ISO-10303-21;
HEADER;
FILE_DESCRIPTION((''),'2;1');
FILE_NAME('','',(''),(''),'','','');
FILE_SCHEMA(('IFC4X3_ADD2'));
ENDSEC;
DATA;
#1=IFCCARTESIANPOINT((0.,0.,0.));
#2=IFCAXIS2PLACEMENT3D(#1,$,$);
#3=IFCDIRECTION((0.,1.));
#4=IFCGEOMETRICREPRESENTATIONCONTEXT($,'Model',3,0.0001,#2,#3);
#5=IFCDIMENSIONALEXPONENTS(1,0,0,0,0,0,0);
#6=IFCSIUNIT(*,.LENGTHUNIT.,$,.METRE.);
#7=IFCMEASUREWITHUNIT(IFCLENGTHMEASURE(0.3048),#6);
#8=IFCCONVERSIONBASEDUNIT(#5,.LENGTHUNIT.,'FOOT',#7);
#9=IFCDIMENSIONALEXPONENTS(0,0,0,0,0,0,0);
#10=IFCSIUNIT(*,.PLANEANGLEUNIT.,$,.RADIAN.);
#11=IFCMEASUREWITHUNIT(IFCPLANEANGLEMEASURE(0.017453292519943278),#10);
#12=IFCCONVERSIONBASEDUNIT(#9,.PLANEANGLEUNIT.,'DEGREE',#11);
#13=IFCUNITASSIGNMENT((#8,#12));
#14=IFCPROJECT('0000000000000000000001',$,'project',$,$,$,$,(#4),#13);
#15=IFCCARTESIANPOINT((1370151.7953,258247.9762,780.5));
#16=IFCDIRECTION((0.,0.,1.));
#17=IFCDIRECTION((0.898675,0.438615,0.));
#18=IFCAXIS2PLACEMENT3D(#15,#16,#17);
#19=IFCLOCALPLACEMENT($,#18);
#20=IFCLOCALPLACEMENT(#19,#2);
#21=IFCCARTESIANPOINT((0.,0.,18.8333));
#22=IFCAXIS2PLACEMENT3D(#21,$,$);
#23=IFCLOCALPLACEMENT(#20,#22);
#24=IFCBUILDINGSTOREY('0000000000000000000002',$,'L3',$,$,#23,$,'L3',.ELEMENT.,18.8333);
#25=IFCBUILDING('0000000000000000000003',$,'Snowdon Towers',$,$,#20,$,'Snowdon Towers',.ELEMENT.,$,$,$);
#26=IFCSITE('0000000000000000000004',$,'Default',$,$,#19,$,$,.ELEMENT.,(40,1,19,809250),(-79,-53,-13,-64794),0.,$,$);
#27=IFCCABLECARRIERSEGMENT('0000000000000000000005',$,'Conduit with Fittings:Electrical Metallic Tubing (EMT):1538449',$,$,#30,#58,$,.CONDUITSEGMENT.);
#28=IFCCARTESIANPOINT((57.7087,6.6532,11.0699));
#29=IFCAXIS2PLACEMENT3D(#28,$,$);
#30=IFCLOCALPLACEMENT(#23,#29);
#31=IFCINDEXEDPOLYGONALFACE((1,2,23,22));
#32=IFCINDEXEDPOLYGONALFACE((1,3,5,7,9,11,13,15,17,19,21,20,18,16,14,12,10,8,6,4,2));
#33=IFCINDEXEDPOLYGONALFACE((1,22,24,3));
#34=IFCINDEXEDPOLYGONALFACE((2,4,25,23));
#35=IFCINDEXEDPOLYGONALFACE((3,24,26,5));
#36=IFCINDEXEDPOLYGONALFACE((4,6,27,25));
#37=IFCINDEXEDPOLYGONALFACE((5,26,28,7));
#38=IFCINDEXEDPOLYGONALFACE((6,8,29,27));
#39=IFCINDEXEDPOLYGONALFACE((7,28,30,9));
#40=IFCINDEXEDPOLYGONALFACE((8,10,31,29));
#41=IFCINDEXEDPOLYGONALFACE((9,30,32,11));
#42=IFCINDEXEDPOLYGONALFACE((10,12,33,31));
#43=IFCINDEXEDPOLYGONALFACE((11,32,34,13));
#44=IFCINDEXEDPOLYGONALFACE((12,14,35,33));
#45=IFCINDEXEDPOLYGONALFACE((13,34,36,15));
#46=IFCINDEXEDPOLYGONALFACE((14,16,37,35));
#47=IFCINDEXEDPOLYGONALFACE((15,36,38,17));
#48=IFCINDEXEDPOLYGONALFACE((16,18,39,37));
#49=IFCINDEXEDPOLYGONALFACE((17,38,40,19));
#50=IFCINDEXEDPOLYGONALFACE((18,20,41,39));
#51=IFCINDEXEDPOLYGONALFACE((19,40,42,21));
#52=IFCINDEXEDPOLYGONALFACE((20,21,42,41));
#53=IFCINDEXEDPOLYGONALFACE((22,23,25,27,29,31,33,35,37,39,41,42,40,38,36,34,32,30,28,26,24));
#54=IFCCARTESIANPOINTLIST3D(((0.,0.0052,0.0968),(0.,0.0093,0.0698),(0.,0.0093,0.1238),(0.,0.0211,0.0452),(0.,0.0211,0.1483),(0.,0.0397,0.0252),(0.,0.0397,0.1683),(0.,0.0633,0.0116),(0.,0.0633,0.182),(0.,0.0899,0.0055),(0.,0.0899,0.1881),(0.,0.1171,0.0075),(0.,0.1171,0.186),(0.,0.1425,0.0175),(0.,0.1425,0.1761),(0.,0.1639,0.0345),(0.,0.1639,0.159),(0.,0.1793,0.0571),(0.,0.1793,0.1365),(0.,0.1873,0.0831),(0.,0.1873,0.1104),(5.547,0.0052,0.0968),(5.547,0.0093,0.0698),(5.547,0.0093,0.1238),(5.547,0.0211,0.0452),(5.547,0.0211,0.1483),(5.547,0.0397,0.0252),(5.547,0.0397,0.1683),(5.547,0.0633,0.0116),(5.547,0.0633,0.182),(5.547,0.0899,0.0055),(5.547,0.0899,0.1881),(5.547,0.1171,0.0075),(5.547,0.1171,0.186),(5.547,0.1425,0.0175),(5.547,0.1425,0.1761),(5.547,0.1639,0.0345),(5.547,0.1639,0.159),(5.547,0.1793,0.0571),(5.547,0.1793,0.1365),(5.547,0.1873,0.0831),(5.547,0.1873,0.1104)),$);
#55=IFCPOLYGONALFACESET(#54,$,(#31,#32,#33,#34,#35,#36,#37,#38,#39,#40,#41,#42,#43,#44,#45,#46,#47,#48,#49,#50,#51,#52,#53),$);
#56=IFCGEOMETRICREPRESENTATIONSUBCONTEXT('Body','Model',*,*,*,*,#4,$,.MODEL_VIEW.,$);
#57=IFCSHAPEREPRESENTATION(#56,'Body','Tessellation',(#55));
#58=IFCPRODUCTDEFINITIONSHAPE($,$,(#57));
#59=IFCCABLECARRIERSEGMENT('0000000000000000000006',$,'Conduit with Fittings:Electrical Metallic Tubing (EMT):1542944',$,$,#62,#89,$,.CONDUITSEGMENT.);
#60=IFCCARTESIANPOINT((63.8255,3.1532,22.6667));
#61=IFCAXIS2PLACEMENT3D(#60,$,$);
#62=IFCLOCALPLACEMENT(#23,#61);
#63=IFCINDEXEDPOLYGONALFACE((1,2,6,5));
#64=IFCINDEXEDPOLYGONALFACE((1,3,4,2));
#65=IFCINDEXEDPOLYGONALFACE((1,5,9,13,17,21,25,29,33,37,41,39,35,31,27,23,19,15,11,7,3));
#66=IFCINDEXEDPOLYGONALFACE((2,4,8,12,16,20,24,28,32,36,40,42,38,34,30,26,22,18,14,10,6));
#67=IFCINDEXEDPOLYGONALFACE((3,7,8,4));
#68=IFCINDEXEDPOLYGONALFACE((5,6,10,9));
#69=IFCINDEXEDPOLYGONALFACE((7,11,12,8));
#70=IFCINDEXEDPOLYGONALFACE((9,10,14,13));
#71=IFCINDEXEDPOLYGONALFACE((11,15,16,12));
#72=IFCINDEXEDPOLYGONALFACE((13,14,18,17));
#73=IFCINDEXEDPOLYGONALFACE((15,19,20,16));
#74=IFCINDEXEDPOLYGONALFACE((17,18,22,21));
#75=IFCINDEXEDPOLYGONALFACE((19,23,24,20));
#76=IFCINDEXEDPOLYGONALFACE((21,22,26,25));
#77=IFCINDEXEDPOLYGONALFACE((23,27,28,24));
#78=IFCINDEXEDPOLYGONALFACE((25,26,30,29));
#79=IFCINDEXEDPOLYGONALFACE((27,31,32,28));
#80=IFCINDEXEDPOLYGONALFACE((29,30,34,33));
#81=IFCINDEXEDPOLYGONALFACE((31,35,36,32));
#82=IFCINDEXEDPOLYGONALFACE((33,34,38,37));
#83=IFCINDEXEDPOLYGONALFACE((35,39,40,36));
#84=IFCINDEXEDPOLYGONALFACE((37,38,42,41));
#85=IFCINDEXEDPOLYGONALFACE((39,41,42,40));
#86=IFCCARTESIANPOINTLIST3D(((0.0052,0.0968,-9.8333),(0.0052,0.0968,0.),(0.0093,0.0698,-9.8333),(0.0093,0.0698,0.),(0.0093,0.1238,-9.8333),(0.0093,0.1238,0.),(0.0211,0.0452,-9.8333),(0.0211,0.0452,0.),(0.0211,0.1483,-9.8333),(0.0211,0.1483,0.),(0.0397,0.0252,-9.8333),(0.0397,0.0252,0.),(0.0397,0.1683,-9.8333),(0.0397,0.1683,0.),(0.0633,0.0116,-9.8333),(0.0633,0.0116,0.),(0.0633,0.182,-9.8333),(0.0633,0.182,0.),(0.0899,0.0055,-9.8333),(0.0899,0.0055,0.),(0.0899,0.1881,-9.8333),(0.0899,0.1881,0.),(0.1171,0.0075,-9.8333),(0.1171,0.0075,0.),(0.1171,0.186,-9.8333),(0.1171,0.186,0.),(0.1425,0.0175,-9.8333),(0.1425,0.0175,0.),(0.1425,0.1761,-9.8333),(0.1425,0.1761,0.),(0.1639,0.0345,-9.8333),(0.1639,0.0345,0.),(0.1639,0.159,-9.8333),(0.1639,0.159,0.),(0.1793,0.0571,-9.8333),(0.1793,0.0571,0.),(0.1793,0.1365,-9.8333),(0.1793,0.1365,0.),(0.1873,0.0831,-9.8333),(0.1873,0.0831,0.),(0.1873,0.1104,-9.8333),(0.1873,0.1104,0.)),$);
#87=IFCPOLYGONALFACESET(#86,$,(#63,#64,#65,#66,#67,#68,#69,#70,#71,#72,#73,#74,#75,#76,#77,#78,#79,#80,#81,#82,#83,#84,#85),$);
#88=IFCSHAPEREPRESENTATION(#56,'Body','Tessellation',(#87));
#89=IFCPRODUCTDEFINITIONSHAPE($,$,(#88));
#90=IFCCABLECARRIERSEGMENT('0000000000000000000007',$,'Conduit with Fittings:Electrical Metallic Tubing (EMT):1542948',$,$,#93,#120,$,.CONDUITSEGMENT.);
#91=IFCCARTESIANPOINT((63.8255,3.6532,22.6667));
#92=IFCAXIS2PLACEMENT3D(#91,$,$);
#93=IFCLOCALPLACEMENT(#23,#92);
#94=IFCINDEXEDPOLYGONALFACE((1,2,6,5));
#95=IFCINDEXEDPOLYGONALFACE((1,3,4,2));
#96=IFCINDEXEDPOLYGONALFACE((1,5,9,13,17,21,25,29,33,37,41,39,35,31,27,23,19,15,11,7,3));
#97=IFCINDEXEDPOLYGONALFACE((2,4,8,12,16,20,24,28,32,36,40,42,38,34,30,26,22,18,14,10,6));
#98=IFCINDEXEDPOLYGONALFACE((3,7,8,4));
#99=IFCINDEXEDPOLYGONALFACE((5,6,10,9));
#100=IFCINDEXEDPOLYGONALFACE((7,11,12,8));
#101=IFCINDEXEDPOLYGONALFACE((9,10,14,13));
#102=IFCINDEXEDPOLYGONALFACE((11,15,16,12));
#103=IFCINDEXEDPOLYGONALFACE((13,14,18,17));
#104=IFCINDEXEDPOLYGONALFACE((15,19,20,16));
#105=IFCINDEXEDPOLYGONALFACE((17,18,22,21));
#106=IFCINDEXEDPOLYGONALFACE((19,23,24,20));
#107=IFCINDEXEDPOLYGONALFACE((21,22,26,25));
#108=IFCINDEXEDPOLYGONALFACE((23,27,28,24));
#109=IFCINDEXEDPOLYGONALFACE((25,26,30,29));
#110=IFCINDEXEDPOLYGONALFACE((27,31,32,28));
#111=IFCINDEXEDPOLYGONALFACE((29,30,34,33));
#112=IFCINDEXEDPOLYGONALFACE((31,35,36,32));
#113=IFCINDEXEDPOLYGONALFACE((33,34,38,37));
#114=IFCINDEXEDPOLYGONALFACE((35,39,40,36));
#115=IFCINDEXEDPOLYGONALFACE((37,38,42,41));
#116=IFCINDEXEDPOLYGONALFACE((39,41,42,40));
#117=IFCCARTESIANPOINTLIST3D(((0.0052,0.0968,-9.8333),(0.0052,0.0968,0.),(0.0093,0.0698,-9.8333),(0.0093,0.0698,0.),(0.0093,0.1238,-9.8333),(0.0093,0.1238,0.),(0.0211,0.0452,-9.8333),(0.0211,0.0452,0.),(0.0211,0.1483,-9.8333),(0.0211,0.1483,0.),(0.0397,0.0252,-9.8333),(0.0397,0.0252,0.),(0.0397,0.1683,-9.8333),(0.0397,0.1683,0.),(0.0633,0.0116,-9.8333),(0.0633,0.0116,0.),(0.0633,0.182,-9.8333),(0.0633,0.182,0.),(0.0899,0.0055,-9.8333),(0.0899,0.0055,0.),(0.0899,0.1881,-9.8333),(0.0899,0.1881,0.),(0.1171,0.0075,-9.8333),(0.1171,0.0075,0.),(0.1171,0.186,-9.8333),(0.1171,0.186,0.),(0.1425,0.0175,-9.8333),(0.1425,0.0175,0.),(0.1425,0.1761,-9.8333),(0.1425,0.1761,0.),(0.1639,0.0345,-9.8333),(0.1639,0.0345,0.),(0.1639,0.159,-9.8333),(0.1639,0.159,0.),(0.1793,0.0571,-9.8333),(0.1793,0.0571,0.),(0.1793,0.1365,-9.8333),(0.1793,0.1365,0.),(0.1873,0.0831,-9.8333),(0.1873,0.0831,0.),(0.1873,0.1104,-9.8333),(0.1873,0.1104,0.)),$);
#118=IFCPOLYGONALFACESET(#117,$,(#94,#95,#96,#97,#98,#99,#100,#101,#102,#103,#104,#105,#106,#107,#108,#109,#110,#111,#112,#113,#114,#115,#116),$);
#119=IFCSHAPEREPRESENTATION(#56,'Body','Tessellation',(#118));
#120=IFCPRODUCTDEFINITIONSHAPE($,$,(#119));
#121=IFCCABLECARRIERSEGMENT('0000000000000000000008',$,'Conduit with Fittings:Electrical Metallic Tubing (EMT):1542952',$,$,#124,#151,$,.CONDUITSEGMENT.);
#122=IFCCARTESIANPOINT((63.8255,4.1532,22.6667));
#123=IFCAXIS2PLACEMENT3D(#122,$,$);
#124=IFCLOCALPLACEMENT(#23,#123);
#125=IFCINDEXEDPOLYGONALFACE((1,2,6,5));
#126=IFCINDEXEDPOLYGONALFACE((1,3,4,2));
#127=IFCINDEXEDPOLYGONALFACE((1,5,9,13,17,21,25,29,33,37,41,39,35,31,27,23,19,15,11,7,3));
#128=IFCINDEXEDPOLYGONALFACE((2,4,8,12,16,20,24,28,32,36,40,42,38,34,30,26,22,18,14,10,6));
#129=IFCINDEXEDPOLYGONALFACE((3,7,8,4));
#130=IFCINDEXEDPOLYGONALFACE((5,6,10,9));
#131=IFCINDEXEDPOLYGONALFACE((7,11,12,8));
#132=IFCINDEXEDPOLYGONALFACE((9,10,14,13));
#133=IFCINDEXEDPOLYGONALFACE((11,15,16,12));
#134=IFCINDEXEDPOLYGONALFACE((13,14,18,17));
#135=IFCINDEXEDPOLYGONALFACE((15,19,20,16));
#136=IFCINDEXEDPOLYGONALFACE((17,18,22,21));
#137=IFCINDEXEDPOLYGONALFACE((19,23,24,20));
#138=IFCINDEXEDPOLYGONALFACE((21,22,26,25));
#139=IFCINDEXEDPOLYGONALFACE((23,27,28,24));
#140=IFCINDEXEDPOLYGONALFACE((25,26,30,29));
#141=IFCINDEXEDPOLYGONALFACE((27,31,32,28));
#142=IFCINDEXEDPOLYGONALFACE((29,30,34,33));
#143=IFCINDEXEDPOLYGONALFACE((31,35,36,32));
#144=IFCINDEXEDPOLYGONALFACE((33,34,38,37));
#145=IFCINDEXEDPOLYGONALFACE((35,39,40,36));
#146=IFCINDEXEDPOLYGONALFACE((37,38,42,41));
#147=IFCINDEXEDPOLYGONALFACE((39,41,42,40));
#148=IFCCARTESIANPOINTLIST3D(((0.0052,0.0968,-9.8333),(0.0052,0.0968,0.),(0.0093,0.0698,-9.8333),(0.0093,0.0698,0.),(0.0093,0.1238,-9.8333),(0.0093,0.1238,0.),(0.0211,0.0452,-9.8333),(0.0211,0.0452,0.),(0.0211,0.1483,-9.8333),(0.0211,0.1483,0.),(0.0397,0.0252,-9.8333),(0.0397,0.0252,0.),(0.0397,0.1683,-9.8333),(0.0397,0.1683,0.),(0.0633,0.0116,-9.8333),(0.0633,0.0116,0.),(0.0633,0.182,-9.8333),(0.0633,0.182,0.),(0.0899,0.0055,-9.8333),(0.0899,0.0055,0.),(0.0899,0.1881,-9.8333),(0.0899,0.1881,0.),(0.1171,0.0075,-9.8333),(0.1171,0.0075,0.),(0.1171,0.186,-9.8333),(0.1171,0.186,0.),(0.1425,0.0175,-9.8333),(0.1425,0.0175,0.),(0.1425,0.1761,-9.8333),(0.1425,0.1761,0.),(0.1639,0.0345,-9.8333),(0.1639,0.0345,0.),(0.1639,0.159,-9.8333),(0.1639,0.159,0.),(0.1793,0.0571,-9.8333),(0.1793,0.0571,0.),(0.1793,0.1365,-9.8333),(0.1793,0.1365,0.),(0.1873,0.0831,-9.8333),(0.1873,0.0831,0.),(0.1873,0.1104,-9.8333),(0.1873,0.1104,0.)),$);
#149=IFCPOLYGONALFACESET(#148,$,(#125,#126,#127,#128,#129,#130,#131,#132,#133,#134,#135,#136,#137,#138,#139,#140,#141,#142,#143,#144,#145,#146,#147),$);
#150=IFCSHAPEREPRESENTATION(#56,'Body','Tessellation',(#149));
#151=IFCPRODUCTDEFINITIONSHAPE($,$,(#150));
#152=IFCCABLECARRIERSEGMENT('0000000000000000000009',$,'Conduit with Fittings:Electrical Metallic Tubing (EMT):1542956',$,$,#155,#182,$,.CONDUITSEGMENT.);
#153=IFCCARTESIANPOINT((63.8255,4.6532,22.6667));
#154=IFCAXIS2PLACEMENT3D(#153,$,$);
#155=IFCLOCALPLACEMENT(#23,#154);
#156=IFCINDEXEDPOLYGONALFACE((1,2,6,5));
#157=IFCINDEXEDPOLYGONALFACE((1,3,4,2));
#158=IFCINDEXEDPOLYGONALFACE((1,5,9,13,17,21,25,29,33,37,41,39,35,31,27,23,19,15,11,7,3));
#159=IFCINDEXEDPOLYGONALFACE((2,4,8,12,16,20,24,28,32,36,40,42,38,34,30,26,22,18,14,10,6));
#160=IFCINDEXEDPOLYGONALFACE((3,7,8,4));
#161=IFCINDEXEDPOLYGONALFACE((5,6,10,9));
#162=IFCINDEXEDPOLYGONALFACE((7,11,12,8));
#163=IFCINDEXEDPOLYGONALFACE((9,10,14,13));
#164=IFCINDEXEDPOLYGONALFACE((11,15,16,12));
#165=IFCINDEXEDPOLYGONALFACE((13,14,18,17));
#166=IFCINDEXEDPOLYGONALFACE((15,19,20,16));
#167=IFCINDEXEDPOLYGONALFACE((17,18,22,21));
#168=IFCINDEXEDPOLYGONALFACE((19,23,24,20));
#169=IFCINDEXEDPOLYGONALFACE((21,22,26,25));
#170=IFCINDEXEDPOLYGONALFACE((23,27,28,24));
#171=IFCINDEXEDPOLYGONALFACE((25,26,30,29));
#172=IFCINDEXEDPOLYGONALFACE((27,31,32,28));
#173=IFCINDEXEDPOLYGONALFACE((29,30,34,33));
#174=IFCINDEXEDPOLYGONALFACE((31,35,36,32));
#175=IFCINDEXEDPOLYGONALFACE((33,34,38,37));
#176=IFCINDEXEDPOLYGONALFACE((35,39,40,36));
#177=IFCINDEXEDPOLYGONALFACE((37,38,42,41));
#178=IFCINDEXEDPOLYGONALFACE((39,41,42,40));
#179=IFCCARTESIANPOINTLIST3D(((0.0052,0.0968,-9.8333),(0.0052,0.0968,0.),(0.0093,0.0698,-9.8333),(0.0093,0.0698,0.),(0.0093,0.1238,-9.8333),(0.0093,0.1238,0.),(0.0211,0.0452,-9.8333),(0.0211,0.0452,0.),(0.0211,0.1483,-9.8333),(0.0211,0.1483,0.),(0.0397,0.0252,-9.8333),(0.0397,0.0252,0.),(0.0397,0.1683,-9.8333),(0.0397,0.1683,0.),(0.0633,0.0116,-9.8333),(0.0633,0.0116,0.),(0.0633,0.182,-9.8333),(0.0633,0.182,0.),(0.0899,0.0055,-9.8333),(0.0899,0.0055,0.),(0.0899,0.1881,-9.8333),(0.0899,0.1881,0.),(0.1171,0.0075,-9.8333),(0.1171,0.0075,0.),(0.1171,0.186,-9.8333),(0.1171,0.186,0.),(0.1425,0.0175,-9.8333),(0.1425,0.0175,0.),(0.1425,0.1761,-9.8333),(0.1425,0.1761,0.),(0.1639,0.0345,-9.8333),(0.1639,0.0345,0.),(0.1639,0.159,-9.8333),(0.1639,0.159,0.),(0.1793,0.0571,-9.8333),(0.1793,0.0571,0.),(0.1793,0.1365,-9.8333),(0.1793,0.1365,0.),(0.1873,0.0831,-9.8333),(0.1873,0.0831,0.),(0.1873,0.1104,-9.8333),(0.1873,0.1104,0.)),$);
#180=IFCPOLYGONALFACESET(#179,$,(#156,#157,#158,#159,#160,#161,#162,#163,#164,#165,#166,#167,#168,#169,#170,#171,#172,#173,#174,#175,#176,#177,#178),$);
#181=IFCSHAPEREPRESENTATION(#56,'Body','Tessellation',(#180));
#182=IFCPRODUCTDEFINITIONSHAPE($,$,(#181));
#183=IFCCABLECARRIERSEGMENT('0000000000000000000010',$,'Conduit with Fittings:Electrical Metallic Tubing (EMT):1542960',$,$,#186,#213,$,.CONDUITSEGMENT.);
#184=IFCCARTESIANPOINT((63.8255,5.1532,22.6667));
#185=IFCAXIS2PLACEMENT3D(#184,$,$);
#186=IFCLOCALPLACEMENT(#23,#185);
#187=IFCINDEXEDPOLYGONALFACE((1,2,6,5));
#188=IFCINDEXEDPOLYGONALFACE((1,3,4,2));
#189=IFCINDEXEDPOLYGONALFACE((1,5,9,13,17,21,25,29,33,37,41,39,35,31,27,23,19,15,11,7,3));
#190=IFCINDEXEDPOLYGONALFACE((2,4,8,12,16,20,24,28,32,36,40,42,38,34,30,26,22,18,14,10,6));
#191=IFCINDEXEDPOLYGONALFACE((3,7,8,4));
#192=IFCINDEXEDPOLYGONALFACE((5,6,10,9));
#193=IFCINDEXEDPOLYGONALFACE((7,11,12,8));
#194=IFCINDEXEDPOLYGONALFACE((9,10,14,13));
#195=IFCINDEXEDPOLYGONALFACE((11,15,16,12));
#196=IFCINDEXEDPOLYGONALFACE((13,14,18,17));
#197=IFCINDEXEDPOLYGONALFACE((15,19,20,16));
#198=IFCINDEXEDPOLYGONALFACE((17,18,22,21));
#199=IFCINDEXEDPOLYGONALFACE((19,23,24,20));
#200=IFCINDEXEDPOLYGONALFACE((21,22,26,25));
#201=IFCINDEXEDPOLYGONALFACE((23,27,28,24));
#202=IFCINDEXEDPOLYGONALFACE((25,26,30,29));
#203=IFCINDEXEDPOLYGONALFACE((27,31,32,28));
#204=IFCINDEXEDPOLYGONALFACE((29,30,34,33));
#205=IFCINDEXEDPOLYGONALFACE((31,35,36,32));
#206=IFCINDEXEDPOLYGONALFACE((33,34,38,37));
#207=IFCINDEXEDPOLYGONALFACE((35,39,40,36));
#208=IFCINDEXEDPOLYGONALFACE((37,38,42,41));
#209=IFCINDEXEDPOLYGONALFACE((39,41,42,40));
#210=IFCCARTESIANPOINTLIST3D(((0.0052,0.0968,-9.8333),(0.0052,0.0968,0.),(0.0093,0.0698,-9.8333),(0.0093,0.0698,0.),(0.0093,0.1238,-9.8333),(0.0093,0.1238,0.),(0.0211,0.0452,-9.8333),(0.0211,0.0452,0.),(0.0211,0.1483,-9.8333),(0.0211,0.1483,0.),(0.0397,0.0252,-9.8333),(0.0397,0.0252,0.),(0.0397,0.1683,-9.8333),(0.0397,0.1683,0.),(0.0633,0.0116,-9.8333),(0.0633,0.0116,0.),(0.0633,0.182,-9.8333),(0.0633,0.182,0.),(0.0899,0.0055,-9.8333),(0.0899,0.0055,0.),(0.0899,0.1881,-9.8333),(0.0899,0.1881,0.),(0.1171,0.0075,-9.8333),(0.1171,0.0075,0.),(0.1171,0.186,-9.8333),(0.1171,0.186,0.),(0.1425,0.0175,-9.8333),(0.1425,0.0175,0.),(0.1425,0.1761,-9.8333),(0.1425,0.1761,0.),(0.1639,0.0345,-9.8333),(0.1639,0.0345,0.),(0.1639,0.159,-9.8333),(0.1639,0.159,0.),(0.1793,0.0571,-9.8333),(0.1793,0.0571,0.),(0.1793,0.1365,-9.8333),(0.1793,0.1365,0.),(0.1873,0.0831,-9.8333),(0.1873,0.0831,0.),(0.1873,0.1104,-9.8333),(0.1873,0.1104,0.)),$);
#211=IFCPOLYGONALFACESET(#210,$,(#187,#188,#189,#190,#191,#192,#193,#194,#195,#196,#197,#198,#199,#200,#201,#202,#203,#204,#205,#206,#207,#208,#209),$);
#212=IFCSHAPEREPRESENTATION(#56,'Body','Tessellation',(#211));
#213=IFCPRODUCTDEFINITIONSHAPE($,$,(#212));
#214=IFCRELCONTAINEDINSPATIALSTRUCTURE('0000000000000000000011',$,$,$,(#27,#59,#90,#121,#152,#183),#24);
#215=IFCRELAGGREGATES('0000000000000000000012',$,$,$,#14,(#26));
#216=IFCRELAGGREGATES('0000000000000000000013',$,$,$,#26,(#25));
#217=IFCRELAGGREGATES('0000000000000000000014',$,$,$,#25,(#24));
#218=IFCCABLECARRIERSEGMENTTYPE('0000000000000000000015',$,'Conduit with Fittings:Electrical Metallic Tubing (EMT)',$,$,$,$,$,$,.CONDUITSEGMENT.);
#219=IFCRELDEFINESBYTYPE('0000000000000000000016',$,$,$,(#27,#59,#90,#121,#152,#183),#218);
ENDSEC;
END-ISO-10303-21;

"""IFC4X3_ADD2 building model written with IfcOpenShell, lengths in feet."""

from ifc_helpers import new_model, entity, si_unit, converted_unit, direction, frame, frame_2d, origin, origin_2d_with_axis, place, context, subcontext, project, spatial, circle, extrude, type_object, element, save


model = new_model("IFC4X3_ADD2")

# Units and contexts
model_context = context("Model", 3, precision=0.0001, world=origin(), true_north=direction((0.0, 1.0)))
body_context = subcontext(model_context, "Body", "Model", "MODEL_VIEW")
ifc_project = project(units=[converted_unit("LENGTHUNIT", "FOOT", entity("IfcLengthMeasure", 0.3048), si_unit("LENGTHUNIT", "METRE"), dimensions=[1, 0, 0, 0, 0, 0, 0]), converted_unit("PLANEANGLEUNIT", "DEGREE", entity("IfcPlaneAngleMeasure", 0.017453292519943278), si_unit("PLANEANGLEUNIT", "RADIAN"), dimensions=[0, 0, 0, 0, 0, 0, 0])], contexts=[model_context])

# Site, building, storey
site_placement = place(None, frame((1370151.7953, 258247.9762, 780.5), z_axis=(0.0, 0.0, 1.0), x_axis=(0.898675, 0.438615, 0.0)))
site = spatial("IfcSite", under=ifc_project, at=site_placement, Name="Default", CompositionType="ELEMENT", RefLatitude=(40, 1, 19, 809250), RefLongitude=(-79, -53, -13, -64794), RefElevation=0.0)
building_placement = place(site_placement, origin())
building = spatial("IfcBuilding", under=site, at=building_placement, Name="Snowdon Towers", LongName="Snowdon Towers", CompositionType="ELEMENT")
storey_placement = place(building_placement, frame((0.0, 0.0, 18.8333)))
storey = spatial("IfcBuildingStorey", under=building, at=storey_placement, Name="L3", LongName="L3", CompositionType="ELEMENT", Elevation=18.8333)

# Cable carrier segments
cable_carrier_segment_type = type_object("IfcCableCarrierSegmentType", Name="Conduit with Fittings:Electrical Metallic Tubing (EMT)", PredefinedType="CONDUITSEGMENT")
cable_carrier_segment_1_placement = place(storey_placement, frame((57.7087, 6.6532, 11.0699)))
element("IfcCableCarrierSegment", 1, at=cable_carrier_segment_1_placement, inside=storey, type_object=cable_carrier_segment_type, Name="Conduit with Fittings:Electrical Metallic Tubing (EMT):1538449", PredefinedType="CONDUITSEGMENT", context=body_context, shape_type="SweptSolid", body=[
    extrude(circle(Radius=0.0915, at=frame_2d((0.0, 0.0), x_axis=(1.0, 0.0))), frame((0.0, 0.0968, 0.0968), z_axis=(1.0, 0.0, 0.0), x_axis=(0.0, -1.0, 0.0)), (0.0, 0.0, 1.0), 5.547),
])
for number, where, name in (
    (2, (63.8255, 3.1532, 22.6667), "Conduit with Fittings:Electrical Metallic Tubing (EMT):1542944"),
    (3, (63.8255, 3.6532, 22.6667), "Conduit with Fittings:Electrical Metallic Tubing (EMT):1542948"),
    (4, (63.8255, 4.1532, 22.6667), "Conduit with Fittings:Electrical Metallic Tubing (EMT):1542952"),
    (5, (63.8255, 4.6532, 22.6667), "Conduit with Fittings:Electrical Metallic Tubing (EMT):1542956"),
    (6, (63.8255, 5.1532, 22.6667), "Conduit with Fittings:Electrical Metallic Tubing (EMT):1542960"),
):
    element("IfcCableCarrierSegment", number, at=place(storey_placement, frame(where)), inside=storey, type_object=cable_carrier_segment_type, Name=name, PredefinedType="CONDUITSEGMENT", context=body_context, shape_type="SweptSolid", body=[
        extrude(circle(Radius=0.0915, at=origin_2d_with_axis()), frame((0.0968, 0.0968, -9.8333), z_axis=(0.0, 0.0, 1.0), x_axis=(-1.0, 0.0, 0.0)), (0.0, 0.0, 1.0), 9.8333),
    ])

save(model, "model.ifc")
